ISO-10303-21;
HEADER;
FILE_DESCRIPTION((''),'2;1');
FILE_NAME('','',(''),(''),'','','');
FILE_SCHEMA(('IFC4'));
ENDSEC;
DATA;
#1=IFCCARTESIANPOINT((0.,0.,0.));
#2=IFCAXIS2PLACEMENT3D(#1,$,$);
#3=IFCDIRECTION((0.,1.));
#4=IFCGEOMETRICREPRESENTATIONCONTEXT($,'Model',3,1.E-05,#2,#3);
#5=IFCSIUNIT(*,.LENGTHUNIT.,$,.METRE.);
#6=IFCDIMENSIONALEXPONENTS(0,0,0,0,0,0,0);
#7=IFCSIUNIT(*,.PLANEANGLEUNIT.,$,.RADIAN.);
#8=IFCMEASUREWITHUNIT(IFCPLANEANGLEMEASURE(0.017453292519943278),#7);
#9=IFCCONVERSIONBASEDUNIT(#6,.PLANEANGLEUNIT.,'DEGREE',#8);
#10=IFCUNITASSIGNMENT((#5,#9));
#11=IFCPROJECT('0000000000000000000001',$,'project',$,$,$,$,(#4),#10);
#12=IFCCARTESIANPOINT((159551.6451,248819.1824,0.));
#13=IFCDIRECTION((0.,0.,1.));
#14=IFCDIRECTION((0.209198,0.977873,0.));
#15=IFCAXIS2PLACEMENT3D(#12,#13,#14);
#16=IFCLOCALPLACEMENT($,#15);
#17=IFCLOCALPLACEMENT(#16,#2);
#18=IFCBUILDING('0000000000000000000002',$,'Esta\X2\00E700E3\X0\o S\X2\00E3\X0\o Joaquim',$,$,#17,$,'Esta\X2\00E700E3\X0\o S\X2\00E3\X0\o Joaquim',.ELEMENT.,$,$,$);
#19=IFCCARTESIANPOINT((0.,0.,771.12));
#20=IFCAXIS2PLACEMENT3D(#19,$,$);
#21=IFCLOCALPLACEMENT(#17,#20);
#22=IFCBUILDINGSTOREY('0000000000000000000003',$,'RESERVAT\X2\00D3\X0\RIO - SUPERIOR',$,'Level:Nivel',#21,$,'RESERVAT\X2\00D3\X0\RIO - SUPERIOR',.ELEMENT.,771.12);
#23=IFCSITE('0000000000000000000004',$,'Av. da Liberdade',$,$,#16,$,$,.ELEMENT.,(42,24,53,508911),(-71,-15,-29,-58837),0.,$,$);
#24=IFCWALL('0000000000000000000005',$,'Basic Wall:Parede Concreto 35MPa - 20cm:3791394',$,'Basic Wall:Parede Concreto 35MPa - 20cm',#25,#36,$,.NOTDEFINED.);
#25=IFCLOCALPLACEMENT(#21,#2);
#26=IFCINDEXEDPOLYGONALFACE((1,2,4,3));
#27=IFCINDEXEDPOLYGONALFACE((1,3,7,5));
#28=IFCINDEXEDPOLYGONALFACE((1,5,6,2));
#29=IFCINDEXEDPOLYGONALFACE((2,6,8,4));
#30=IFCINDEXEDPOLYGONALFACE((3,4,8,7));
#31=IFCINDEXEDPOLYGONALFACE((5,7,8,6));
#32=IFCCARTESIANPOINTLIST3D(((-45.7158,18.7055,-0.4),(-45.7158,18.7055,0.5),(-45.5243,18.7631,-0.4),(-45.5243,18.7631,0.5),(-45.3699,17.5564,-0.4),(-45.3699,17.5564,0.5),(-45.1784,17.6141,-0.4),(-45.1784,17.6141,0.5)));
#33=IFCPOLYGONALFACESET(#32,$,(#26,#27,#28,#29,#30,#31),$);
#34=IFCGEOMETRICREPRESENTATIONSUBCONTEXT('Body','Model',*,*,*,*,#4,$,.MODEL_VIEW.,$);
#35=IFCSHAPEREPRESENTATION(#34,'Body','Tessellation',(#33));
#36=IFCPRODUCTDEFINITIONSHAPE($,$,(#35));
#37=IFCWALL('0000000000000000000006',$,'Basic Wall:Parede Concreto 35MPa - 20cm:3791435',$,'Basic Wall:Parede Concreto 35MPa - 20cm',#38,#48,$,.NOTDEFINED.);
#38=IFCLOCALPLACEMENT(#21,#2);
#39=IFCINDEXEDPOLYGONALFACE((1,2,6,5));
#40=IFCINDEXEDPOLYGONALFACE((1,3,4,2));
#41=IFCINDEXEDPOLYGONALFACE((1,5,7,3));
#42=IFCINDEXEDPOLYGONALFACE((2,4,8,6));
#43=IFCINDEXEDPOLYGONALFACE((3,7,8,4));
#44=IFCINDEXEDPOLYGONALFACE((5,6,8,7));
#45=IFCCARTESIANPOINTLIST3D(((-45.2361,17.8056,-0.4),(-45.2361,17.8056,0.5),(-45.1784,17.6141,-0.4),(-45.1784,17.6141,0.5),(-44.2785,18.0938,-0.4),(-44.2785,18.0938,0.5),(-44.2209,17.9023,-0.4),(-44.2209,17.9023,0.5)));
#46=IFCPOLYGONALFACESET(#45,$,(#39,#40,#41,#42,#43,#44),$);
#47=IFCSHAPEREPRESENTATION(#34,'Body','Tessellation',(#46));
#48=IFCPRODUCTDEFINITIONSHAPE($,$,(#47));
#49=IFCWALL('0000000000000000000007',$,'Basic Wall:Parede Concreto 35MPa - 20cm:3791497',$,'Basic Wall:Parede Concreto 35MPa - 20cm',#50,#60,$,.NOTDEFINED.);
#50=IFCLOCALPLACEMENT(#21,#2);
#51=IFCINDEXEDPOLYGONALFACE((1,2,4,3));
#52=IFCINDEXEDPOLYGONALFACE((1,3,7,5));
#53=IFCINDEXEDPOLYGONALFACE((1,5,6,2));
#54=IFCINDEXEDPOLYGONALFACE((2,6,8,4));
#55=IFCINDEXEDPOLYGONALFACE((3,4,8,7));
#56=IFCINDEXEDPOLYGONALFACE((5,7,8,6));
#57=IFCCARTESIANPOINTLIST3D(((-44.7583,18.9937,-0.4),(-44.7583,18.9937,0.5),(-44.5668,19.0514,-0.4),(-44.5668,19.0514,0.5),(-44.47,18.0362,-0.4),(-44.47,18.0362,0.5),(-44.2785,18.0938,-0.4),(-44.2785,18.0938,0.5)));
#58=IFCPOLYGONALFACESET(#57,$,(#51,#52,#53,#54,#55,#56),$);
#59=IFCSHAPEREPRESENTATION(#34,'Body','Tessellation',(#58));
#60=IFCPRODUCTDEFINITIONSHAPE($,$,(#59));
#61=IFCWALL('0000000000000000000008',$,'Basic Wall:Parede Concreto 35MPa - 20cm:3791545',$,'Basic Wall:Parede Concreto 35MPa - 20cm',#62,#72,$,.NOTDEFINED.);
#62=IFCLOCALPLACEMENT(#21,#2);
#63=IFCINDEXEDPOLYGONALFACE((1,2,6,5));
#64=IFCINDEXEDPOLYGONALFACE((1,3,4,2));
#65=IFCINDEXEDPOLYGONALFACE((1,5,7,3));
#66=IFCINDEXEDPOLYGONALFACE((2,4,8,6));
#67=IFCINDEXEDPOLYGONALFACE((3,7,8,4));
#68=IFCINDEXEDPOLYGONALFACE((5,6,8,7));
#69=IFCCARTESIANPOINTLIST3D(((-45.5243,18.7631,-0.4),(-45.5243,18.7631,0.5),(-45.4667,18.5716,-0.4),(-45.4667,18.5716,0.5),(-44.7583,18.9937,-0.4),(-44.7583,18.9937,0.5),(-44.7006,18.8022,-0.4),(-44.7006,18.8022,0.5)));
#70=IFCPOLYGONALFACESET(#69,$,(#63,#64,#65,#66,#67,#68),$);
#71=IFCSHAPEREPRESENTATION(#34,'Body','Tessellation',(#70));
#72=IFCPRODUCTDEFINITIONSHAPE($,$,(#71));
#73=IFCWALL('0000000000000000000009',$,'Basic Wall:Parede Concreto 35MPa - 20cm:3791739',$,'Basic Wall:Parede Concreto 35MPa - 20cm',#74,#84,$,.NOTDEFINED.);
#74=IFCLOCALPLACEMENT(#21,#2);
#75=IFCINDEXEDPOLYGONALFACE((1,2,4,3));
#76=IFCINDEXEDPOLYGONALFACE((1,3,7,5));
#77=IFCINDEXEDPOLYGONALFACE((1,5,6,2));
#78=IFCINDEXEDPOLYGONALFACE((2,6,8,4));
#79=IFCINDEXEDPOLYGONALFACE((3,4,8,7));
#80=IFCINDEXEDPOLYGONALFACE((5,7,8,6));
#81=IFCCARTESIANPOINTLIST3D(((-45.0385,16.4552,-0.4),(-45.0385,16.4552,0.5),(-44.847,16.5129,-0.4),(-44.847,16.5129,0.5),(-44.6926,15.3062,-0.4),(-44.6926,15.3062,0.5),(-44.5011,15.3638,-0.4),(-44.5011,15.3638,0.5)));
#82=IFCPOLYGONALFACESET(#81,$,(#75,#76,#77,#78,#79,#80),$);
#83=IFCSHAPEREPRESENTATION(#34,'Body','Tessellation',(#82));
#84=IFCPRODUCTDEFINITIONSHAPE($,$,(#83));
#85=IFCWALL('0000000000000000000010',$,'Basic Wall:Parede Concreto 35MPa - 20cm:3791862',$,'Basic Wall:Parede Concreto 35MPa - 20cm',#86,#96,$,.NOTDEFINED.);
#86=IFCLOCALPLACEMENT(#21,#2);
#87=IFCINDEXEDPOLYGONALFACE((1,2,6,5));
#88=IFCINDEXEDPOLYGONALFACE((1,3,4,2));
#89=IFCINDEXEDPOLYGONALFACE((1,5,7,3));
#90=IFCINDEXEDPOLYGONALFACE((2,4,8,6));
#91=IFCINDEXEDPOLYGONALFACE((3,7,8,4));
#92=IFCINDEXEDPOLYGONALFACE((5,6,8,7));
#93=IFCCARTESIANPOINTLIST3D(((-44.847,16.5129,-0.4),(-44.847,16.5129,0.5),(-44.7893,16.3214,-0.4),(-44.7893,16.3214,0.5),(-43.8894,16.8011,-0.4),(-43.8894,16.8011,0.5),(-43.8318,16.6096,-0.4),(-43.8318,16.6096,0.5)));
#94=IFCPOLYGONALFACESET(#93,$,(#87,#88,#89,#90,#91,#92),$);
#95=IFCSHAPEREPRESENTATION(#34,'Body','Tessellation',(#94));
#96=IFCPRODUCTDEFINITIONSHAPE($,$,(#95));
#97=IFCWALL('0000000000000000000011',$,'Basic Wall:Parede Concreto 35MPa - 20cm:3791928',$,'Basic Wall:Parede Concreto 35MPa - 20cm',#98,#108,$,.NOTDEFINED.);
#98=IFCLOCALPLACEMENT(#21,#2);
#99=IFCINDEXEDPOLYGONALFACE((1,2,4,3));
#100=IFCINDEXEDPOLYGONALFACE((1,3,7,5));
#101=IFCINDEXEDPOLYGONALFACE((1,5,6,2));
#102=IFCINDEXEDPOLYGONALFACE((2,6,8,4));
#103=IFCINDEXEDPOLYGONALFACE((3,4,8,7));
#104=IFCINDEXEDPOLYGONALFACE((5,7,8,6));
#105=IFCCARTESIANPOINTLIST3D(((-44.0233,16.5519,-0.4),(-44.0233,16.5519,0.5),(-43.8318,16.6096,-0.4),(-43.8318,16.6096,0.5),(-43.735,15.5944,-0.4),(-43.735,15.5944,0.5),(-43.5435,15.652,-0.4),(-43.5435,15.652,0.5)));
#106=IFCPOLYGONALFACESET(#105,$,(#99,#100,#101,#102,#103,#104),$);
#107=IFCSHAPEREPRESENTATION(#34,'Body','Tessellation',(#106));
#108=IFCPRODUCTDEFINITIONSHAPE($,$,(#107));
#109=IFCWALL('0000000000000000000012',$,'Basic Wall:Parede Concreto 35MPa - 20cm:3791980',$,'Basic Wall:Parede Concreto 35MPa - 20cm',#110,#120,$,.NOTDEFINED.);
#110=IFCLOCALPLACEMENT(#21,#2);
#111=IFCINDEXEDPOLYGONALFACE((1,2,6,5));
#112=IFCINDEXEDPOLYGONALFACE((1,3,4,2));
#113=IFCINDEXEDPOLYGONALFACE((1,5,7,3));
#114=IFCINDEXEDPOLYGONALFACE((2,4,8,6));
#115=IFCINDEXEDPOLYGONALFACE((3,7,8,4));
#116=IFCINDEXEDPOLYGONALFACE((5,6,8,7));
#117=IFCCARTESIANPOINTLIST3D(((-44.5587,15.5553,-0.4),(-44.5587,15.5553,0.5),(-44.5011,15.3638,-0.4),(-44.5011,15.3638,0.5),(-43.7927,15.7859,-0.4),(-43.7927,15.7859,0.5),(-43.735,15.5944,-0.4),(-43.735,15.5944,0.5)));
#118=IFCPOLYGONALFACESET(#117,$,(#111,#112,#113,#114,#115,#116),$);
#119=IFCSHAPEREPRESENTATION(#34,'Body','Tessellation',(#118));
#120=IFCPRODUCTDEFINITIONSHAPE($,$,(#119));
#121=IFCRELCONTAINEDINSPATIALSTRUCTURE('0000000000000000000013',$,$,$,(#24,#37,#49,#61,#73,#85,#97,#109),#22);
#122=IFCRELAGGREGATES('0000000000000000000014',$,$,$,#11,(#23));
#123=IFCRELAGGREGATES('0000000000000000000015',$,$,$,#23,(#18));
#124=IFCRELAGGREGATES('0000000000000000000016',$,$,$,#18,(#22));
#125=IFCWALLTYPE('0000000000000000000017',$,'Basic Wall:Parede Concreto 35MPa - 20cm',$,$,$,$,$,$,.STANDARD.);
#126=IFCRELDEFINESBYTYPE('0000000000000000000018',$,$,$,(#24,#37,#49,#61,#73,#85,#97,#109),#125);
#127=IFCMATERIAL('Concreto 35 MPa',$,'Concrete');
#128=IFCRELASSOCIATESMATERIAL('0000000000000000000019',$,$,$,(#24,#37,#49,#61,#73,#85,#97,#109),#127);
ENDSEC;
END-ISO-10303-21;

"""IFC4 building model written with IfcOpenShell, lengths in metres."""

from ifc_helpers import new_model, entity, si_unit, converted_unit, direction, frame, origin, place, context, subcontext, project, spatial, indexed_curve, outline, extrude, material, type_object, element, save


model = new_model("IFC4")

# Units and contexts
model_context = context("Model", 3, precision=1e-05, world=origin(), true_north=direction((0.0, 1.0)))
body_context = subcontext(model_context, "Body", "Model", "MODEL_VIEW")
ifc_project = project(units=[si_unit("LENGTHUNIT", "METRE"), converted_unit("PLANEANGLEUNIT", "DEGREE", entity("IfcPlaneAngleMeasure", 0.017453292519943278), si_unit("PLANEANGLEUNIT", "RADIAN"), dimensions=[0, 0, 0, 0, 0, 0, 0])], contexts=[model_context])

# Site, building, storey
site_placement = place(None, frame((159551.6451, 248819.1824, 0.0), z_axis=(0.0, 0.0, 1.0), x_axis=(0.209198, 0.977873, 0.0)))
site = spatial("IfcSite", under=ifc_project, at=site_placement, Name="Av. da Liberdade", CompositionType="ELEMENT", RefLatitude=(42, 24, 53, 508911), RefLongitude=(-71, -15, -29, -58837), RefElevation=0.0)
building_placement = place(site_placement, origin())
building = spatial("IfcBuilding", under=site, at=building_placement, Name="Estação São Joaquim", LongName="Estação São Joaquim", CompositionType="ELEMENT")
storey_placement = place(building_placement, frame((0.0, 0.0, 771.12)))
storey = spatial("IfcBuildingStorey", under=building, at=storey_placement, Name="RESERVATÓRIO - SUPERIOR", ObjectType="Level:Nivel", LongName="RESERVATÓRIO - SUPERIOR", CompositionType="ELEMENT", Elevation=771.12)

# Shared definitions
ifc_material = material(Name="Concreto 35 MPa", Category="Concrete")

# Walls
wall_type = type_object("IfcWallType", Name="Basic Wall:Parede Concreto 35MPa - 20cm", PredefinedType="STANDARD")
wall_1_placement = place(storey_placement, frame((-45.6201, 18.7343, -0.4), z_axis=(0.0, 0.0, 1.0), x_axis=(0.288234, -0.95756, 0.0)))
element("IfcWall", 1, at=wall_1_placement, inside=storey, type_object=wall_type, material=ifc_material, Name="Basic Wall:Parede Concreto 35MPa - 20cm:3791394", ObjectType="Basic Wall:Parede Concreto 35MPa - 20cm", PredefinedType="NOTDEFINED", context=body_context, shape_type="SweptSolid", body=[
    extrude(outline(indexed_curve([(1.2, 0.1), (0.0, 0.1), (0.0, -0.1), (1.2, -0.1), (1.2, 0.1)], self_intersect=False)), origin(), (0.0, 0.0, 1.0), 0.9),
])
wall_2_placement = place(storey_placement, frame((-45.2073, 17.7098, -0.4), z_axis=(0.0, 0.0, 1.0), x_axis=(0.95756, 0.288234, 0.0)))
element("IfcWall", 2, at=wall_2_placement, inside=storey, type_object=wall_type, material=ifc_material, Name="Basic Wall:Parede Concreto 35MPa - 20cm:3791435", ObjectType="Basic Wall:Parede Concreto 35MPa - 20cm", PredefinedType="NOTDEFINED", context=body_context, shape_type="SweptSolid", body=[
    extrude(outline(indexed_curve([(1.0, 0.1), (0.0, 0.1), (0.0, -0.1), (1.0, -0.1), (1.0, 0.1)], self_intersect=False)), origin(), (0.0, 0.0, 1.0), 0.9),
])
wall_3_placement = place(storey_placement, frame((-44.3743, 18.065, -0.4), z_axis=(0.0, 0.0, 1.0), x_axis=(-0.288234, 0.95756, 0.0)))
element("IfcWall", 3, at=wall_3_placement, inside=storey, type_object=wall_type, material=ifc_material, Name="Basic Wall:Parede Concreto 35MPa - 20cm:3791497", ObjectType="Basic Wall:Parede Concreto 35MPa - 20cm", PredefinedType="NOTDEFINED", context=body_context, shape_type="SweptSolid", body=[
    extrude(outline(indexed_curve([(1.0, 0.1), (0.0, 0.1), (0.0, -0.1), (1.0, -0.1), (1.0, 0.1)], self_intersect=False)), origin(), (0.0, 0.0, 1.0), 0.9),
])
wall_4_placement = place(storey_placement, frame((-44.7294, 18.898, -0.4), z_axis=(0.0, 0.0, 1.0), x_axis=(-0.95756, -0.288234, 0.0)))
element("IfcWall", 4, at=wall_4_placement, inside=storey, type_object=wall_type, material=ifc_material, Name="Basic Wall:Parede Concreto 35MPa - 20cm:3791545", ObjectType="Basic Wall:Parede Concreto 35MPa - 20cm", PredefinedType="NOTDEFINED", context=body_context, shape_type="SweptSolid", body=[
    extrude(outline(indexed_curve([(0.8, 0.1), (0.0, 0.1), (0.0, -0.1), (0.8, -0.1), (0.8, 0.1)], self_intersect=False)), origin(), (0.0, 0.0, 1.0), 0.9),
])
wall_5_placement = place(storey_placement, frame((-44.9427, 16.484, -0.4), z_axis=(0.0, 0.0, 1.0), x_axis=(0.288234, -0.95756, 0.0)))
element("IfcWall", 5, at=wall_5_placement, inside=storey, type_object=wall_type, material=ifc_material, Name="Basic Wall:Parede Concreto 35MPa - 20cm:3791739", ObjectType="Basic Wall:Parede Concreto 35MPa - 20cm", PredefinedType="NOTDEFINED", context=body_context, shape_type="SweptSolid", body=[
    extrude(outline(indexed_curve([(1.2, 0.1), (0.0, 0.1), (0.0, -0.1), (1.2, -0.1), (1.2, 0.1)], self_intersect=False)), origin(), (0.0, 0.0, 1.0), 0.9),
])
wall_6_placement = place(storey_placement, frame((-44.8181, 16.4171, -0.4), z_axis=(0.0, 0.0, 1.0), x_axis=(0.95756, 0.288234, 0.0)))
element("IfcWall", 6, at=wall_6_placement, inside=storey, type_object=wall_type, material=ifc_material, Name="Basic Wall:Parede Concreto 35MPa - 20cm:3791862", ObjectType="Basic Wall:Parede Concreto 35MPa - 20cm", PredefinedType="NOTDEFINED", context=body_context, shape_type="SweptSolid", body=[
    extrude(outline(indexed_curve([(1.0, 0.1), (0.0, 0.1), (0.0, -0.1), (1.0, -0.1), (1.0, 0.1)], self_intersect=False)), origin(), (0.0, 0.0, 1.0), 0.9),
])
wall_7_placement = place(storey_placement, frame((-43.9275, 16.5808, -0.4), z_axis=(0.0, 0.0, 1.0), x_axis=(0.288234, -0.95756, 0.0)))
element("IfcWall", 7, at=wall_7_placement, inside=storey, type_object=wall_type, material=ifc_material, Name="Basic Wall:Parede Concreto 35MPa - 20cm:3791928", ObjectType="Basic Wall:Parede Concreto 35MPa - 20cm", PredefinedType="NOTDEFINED", context=body_context, shape_type="SweptSolid", body=[
    extrude(outline(indexed_curve([(1.0, 0.1), (0.0, 0.1), (0.0, -0.1), (1.0, -0.1), (1.0, 0.1)], self_intersect=False)), origin(), (0.0, 0.0, 1.0), 0.9),
])
wall_8_placement = place(storey_placement, frame((-43.7639, 15.6901, -0.4), z_axis=(0.0, 0.0, 1.0), x_axis=(-0.95756, -0.288234, 0.0)))
element("IfcWall", 8, at=wall_8_placement, inside=storey, type_object=wall_type, material=ifc_material, Name="Basic Wall:Parede Concreto 35MPa - 20cm:3791980", ObjectType="Basic Wall:Parede Concreto 35MPa - 20cm", PredefinedType="NOTDEFINED", context=body_context, shape_type="SweptSolid", body=[
    extrude(outline(indexed_curve([(0.8, 0.1), (0.0, 0.1), (0.0, -0.1), (0.8, -0.1), (0.8, 0.1)], self_intersect=False)), origin(), (0.0, 0.0, 1.0), 0.9),
])

save(model, "model.ifc")
